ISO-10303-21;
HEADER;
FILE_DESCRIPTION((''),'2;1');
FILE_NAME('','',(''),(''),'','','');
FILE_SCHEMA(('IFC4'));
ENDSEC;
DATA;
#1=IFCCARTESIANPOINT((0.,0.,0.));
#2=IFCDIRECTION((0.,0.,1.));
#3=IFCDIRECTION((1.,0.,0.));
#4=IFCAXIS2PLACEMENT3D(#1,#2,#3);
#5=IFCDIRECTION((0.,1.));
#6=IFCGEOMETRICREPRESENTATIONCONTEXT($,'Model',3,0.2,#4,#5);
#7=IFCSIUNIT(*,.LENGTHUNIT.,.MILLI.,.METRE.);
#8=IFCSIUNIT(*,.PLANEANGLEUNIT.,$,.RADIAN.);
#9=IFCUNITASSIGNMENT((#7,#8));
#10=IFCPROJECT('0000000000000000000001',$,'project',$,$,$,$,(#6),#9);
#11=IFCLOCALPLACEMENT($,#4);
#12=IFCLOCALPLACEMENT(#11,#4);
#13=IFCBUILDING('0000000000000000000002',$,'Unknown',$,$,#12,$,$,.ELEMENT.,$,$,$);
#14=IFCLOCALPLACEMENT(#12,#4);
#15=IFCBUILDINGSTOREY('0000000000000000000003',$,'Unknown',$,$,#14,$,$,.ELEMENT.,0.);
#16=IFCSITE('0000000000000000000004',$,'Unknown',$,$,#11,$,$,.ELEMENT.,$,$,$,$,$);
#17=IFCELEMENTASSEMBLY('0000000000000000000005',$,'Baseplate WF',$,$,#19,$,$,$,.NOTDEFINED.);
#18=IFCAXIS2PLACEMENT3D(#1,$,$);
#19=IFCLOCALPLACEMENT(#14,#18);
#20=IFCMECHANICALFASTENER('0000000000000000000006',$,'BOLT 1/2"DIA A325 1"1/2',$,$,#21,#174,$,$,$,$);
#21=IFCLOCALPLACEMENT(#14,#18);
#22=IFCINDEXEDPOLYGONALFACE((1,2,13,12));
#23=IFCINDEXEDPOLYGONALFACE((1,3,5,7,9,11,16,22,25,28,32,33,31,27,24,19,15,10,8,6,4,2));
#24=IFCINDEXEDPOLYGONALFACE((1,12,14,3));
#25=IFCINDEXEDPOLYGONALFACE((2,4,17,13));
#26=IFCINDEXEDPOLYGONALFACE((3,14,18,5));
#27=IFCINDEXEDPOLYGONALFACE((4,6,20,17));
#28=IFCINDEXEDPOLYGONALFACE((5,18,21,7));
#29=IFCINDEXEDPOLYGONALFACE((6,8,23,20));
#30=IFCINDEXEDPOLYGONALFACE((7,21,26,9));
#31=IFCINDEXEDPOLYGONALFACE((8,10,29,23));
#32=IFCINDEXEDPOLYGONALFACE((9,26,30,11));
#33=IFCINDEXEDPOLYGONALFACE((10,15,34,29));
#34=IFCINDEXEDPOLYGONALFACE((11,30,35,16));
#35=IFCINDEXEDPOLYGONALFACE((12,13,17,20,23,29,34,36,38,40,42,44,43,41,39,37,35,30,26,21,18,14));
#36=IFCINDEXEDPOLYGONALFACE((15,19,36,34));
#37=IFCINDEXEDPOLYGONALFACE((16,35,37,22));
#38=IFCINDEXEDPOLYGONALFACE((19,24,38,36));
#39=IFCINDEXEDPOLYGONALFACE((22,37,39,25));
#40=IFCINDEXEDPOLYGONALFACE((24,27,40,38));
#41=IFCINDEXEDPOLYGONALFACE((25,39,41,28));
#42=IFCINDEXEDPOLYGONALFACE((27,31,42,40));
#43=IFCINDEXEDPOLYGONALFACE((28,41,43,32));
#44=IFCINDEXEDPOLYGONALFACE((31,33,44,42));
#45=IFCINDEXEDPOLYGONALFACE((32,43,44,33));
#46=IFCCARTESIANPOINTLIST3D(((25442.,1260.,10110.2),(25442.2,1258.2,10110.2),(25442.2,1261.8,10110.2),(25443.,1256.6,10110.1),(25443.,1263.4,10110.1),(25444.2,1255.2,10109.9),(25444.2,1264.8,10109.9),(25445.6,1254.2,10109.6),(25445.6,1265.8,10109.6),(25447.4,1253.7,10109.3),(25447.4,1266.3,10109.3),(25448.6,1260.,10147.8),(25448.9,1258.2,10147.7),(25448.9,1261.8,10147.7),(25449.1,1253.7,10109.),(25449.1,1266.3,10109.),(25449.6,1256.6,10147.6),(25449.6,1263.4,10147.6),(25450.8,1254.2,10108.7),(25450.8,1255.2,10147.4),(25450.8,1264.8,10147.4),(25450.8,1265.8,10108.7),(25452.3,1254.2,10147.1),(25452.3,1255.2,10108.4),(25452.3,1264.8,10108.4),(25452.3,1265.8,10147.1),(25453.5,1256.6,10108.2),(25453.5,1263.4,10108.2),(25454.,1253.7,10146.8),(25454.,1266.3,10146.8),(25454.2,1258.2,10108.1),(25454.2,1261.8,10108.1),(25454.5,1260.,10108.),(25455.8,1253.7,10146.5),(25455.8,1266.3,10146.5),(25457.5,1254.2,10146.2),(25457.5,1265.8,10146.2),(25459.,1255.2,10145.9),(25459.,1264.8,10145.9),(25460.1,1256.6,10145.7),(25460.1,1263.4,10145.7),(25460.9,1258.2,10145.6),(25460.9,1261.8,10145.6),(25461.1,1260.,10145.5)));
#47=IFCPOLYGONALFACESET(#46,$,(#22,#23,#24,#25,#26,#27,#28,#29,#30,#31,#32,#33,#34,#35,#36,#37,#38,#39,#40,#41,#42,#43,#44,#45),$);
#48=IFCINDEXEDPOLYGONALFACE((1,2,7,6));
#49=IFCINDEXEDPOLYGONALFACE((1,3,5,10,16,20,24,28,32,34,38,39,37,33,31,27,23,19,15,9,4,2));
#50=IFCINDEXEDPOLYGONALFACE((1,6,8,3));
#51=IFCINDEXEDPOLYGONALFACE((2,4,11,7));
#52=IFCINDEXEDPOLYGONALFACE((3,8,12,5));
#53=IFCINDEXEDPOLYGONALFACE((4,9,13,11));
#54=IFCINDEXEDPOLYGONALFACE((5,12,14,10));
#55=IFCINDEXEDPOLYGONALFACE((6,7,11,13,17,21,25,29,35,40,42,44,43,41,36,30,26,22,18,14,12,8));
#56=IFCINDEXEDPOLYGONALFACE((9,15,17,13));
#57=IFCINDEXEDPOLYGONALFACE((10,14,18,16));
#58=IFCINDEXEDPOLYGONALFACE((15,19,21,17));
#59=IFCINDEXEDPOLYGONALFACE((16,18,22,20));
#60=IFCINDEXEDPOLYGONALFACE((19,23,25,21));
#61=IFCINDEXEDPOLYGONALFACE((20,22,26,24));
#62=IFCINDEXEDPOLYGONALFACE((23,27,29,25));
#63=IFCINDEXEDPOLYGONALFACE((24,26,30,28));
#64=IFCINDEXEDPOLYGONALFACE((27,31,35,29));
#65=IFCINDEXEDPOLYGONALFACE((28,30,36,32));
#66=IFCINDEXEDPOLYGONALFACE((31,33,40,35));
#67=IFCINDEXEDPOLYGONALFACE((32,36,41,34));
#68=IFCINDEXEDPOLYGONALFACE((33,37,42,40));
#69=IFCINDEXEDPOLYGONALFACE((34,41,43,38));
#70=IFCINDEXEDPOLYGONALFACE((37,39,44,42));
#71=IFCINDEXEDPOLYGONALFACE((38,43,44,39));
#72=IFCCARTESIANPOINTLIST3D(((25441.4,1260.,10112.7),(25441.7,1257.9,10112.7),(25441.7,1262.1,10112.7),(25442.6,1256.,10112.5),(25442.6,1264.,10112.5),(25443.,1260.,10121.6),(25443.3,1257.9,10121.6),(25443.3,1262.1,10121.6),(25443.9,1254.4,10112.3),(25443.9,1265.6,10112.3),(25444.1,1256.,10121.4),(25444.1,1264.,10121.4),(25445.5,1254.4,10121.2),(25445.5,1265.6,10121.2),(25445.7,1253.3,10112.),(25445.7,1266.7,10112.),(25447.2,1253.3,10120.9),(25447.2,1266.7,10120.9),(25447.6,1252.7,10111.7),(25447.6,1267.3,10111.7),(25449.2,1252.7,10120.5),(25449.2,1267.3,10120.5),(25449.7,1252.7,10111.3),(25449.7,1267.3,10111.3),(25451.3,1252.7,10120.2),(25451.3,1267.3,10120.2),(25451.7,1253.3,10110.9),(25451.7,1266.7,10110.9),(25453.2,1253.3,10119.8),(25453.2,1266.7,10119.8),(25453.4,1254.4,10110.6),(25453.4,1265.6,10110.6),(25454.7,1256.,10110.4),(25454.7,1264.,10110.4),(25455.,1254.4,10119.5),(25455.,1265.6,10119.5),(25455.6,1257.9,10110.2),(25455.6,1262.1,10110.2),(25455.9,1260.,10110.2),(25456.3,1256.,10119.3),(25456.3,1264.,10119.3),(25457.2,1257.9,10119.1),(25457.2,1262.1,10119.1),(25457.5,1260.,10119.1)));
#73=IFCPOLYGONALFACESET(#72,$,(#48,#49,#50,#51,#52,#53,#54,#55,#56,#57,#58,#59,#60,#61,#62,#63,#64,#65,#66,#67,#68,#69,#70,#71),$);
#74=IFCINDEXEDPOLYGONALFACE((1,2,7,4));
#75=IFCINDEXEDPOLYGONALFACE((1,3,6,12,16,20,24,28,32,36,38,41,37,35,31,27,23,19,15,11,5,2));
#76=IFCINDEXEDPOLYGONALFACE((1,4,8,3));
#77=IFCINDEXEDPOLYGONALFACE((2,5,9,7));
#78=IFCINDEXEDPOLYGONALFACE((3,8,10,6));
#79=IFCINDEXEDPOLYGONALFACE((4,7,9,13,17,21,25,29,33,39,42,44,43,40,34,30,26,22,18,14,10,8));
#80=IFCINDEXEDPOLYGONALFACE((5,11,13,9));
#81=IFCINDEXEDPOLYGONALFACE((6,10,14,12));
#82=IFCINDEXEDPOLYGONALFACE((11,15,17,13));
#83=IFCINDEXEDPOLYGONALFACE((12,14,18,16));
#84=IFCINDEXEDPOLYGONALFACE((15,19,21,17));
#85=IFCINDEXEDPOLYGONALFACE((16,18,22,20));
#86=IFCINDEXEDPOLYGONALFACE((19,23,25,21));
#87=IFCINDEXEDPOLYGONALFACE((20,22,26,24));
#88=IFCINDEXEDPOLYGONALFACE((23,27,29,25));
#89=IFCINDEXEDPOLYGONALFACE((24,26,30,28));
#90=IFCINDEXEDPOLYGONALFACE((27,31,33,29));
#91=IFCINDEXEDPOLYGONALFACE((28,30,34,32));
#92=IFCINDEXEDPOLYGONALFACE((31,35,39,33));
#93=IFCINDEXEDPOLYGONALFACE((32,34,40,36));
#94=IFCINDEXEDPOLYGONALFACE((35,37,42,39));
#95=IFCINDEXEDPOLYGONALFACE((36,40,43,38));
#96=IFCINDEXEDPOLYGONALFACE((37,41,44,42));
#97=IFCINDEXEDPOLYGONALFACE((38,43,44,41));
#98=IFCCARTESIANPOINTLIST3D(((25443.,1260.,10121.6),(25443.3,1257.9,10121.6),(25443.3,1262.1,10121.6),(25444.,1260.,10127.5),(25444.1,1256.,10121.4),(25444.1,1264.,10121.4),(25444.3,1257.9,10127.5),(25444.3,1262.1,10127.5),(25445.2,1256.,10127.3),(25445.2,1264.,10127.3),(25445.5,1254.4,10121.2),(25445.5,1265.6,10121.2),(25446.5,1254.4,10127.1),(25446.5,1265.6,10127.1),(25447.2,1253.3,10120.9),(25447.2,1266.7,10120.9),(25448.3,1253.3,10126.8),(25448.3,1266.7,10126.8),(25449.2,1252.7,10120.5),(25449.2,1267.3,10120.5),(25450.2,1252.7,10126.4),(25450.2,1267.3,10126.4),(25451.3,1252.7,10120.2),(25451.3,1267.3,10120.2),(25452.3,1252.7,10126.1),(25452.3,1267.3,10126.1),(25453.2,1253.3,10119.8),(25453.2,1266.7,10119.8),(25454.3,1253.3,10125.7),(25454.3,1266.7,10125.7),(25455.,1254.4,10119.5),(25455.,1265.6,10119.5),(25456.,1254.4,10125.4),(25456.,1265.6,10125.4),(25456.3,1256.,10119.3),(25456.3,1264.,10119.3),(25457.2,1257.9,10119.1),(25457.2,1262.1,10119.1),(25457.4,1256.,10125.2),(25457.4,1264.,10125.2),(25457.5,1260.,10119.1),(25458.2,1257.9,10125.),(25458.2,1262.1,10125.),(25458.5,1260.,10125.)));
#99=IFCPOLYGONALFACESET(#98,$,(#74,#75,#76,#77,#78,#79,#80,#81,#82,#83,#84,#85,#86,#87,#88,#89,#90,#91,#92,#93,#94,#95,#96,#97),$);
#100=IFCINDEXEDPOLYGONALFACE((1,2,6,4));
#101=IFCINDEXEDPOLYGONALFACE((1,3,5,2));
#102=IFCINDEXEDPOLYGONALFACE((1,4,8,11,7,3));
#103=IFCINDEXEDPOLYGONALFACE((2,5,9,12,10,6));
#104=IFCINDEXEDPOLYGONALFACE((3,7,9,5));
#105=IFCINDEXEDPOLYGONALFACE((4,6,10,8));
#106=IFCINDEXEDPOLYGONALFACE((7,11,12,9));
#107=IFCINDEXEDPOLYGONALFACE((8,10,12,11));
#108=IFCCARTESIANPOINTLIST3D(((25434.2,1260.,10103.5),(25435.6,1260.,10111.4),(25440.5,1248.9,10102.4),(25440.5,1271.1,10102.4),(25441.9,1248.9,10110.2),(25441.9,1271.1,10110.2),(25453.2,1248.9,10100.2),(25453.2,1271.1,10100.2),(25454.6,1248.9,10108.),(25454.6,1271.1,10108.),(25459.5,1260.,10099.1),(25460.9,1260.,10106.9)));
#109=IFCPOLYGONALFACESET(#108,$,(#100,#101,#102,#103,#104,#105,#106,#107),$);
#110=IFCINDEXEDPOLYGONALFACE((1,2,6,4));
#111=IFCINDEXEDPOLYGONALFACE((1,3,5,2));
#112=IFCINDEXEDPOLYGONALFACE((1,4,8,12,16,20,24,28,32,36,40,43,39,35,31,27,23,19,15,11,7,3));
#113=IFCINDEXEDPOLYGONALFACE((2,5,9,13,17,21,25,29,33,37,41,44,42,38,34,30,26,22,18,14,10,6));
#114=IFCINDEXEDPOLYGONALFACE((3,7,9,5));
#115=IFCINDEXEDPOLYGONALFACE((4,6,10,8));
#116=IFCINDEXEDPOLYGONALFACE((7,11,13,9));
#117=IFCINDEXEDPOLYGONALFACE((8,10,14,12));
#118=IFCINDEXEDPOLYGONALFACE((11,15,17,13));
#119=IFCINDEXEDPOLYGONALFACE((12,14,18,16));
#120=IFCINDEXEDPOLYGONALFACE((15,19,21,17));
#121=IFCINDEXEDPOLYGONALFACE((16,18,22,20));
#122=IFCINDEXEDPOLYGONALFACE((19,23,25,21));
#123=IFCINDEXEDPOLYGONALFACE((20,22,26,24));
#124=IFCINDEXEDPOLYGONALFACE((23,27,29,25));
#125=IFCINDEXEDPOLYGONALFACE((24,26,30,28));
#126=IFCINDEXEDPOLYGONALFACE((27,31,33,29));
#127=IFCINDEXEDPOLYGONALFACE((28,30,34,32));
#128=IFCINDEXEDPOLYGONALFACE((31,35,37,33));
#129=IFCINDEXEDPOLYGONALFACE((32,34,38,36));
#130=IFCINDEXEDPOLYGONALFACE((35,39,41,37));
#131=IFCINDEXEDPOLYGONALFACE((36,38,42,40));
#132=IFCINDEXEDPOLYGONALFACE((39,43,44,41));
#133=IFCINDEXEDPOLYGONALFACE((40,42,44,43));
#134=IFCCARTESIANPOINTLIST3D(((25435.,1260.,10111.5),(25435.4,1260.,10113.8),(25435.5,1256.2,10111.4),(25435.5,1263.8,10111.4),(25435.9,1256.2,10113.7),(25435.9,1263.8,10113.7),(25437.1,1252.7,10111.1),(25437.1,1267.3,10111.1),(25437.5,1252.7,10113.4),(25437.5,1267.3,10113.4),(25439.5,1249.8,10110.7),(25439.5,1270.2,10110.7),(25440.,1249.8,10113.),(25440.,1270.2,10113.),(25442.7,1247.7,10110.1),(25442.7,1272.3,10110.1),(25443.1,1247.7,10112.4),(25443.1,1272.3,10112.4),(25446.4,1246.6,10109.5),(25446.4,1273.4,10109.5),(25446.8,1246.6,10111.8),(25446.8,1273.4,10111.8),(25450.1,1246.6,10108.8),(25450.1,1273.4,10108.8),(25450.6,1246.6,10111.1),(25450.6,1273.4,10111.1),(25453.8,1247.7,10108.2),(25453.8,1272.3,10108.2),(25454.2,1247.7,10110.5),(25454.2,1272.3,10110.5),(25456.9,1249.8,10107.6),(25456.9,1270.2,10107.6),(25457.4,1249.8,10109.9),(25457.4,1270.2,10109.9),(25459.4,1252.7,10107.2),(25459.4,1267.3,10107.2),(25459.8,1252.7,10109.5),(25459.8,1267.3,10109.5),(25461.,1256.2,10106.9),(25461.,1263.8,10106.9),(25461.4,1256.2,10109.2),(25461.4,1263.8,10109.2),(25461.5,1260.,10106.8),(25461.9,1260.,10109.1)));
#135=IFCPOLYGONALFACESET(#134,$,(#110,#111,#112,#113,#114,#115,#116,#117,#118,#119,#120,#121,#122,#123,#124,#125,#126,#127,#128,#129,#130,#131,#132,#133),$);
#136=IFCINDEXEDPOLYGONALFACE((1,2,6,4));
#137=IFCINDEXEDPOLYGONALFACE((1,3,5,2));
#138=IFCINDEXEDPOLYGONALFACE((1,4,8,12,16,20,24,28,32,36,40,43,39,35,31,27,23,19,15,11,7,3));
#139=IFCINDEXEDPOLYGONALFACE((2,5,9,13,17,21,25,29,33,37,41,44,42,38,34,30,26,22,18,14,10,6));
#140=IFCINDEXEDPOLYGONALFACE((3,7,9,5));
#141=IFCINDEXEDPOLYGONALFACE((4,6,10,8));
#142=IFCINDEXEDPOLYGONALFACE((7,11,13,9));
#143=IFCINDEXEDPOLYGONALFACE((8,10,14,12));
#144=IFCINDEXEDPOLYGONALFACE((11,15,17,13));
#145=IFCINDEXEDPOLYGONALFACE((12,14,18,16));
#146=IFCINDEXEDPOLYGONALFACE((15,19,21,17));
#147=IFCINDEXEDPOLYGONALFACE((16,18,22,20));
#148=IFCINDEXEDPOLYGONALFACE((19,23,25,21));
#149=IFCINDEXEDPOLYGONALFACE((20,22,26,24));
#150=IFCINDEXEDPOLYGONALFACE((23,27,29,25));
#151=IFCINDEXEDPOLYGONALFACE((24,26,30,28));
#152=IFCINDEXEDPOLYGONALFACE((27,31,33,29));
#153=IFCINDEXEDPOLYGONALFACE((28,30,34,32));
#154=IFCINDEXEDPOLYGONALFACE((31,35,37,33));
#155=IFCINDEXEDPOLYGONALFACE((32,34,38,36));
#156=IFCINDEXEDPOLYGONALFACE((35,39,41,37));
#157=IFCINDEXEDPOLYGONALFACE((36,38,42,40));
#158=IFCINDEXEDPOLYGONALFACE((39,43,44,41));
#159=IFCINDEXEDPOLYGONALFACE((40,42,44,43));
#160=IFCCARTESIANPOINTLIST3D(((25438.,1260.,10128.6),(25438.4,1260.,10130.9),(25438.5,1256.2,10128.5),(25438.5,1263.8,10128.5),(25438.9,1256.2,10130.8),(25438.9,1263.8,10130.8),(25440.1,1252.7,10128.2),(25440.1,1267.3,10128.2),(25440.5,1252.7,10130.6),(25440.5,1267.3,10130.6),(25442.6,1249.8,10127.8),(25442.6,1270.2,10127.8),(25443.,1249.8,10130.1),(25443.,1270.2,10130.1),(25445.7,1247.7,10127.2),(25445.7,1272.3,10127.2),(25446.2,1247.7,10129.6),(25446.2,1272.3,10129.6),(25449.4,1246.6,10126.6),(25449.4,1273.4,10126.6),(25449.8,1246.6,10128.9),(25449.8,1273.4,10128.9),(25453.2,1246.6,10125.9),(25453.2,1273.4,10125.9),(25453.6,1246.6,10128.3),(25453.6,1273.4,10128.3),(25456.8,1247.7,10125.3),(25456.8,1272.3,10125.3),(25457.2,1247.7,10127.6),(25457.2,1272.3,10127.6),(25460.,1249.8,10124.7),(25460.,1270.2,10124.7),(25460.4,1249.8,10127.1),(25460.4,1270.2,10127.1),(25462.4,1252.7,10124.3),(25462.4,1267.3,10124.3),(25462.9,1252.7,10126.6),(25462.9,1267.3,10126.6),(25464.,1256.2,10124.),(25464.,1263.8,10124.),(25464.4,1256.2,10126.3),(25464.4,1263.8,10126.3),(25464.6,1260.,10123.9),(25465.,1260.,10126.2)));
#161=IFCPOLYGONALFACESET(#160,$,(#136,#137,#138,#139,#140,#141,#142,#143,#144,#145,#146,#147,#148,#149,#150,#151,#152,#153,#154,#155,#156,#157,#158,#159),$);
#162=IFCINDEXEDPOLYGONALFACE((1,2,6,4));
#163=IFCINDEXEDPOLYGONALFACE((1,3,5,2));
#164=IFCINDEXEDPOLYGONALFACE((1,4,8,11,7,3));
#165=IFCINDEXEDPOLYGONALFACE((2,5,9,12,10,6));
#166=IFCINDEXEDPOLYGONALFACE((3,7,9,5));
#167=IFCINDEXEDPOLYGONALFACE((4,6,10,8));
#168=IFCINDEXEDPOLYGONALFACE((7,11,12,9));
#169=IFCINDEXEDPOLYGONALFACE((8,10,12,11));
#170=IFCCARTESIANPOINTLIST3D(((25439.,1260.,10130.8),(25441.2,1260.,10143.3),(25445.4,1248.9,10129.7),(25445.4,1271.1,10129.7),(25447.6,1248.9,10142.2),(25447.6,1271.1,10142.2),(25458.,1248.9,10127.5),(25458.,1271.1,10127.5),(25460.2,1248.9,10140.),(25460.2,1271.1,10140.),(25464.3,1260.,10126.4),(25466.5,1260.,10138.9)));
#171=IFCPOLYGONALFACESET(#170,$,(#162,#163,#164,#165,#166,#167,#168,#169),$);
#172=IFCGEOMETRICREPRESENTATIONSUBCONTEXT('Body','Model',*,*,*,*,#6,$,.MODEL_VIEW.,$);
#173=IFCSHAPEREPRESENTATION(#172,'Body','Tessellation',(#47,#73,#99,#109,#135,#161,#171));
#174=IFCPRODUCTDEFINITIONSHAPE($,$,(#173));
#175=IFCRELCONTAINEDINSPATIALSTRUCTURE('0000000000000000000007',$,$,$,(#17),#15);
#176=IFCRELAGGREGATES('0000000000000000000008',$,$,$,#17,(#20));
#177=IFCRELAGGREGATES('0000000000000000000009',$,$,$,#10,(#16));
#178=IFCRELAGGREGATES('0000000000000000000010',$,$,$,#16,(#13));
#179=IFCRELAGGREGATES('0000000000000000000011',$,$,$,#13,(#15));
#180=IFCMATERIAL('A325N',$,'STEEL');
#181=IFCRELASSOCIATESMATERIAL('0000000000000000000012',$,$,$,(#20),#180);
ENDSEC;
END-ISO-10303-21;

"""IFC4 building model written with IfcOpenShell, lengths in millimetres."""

from ifc_helpers import new_model, si_unit, direction, frame, origin_with_axes, place, context, subcontext, project, spatial, line, arc, indexed_curve, outline, extrude, source, transform, mapped, material, element, aggregate, save


model = new_model("IFC4")

# Units and contexts
model_context = context("Model", 3, precision=0.2, world=origin_with_axes(), true_north=direction((0.0, 1.0)))
body_context = subcontext(model_context, "Body", "Model", "MODEL_VIEW")
ifc_project = project(units=[si_unit("LENGTHUNIT", "METRE", prefix="MILLI"), si_unit("PLANEANGLEUNIT", "RADIAN")], contexts=[model_context])

# Site, building, storey
site_placement = place(None, origin_with_axes())
site = spatial("IfcSite", under=ifc_project, at=site_placement, Name="Unknown", CompositionType="ELEMENT")
building_placement = place(site_placement, origin_with_axes())
building = spatial("IfcBuilding", under=site, at=building_placement, Name="Unknown", CompositionType="ELEMENT")
storey_placement = place(building_placement, origin_with_axes())
storey = spatial("IfcBuildingStorey", under=building, at=storey_placement, Name="Unknown", CompositionType="ELEMENT", Elevation=0.0)

# Element assembly
assembly_1_placement = place(storey_placement, frame((25480.3, 1290.0, 10118.1), z_axis=(-0.173648, 0.0, -0.984808), x_axis=(0.0, -1.0, 0.0)))
assembly_1 = element("IfcElementAssembly", 1, at=assembly_1_placement, inside=storey, Name="Baseplate WF", PredefinedType="NOTDEFINED")

# Mechanical fastener
ifc_material_1 = material(Name="A325N", Category="STEEL")
shared_shape_1 = source(origin_with_axes(), body_context, "Body", "SweptSolid", [
    extrude(outline(indexed_curve([(6.3, 0.0), (0.0, 6.3), (-6.3, 0.0), (0.0, -6.3)], segments=[arc(1, 2, 3), arc(3, 4, 1)])), frame((0.0, 0.0, 17.4), z_axis=(0.0, 0.0, -1.0), x_axis=(0.0, 1.0, 0.0)), (0.0, 0.0, 1.0), 38.1),
    extrude(outline(indexed_curve([(7.3, 0.0), (0.0, 7.3), (-7.3, 0.0), (0.0, -7.3)], segments=[arc(1, 2, 3), arc(3, 4, 1)])), frame((0.0, 0.0, 15.0), z_axis=(0.0, 0.0, -1.0), x_axis=(0.0, 1.0, 0.0)), (0.0, 0.0, 1.0), 9.0),
    extrude(outline(indexed_curve([(7.3, 0.0), (0.0, 7.3), (-7.3, 0.0), (0.0, -7.3)], segments=[arc(1, 2, 3), arc(3, 4, 1)])), frame((0.0, 0.0, 6.0), z_axis=(0.0, 0.0, -1.0), x_axis=(0.0, 1.0, 0.0)), (0.0, 0.0, 1.0), 6.0),
    extrude(outline(indexed_curve([(12.8, 0.0), (6.4, 11.1), (-6.4, 11.1), (-12.8, 0.0), (-6.4, -11.1), (6.4, -11.1)], segments=[line(1, 2, 3, 4, 5, 6, 1)])), frame((0.0, 0.0, 25.3), z_axis=(0.0, 0.0, -1.0), x_axis=(0.0, 1.0, 0.0)), (0.0, 0.0, 1.0), 7.9),
    extrude(outline(indexed_curve([(13.5, 0.0), (0.0, 13.5), (-13.5, 0.0), (0.0, -13.5)], segments=[arc(1, 2, 3), arc(3, 4, 1)])), frame((0.0, 0.0, 17.4), z_axis=(0.0, 0.0, -1.0), x_axis=(0.0, 1.0, 0.0)), (0.0, 0.0, 1.0), 2.4),
    extrude(outline(indexed_curve([(13.5, 0.0), (0.0, 13.5), (-13.5, 0.0), (0.0, -13.5)], segments=[arc(1, 2, 3), arc(3, 4, 1)])), frame((0.0, 0.0, 0.0), z_axis=(0.0, 0.0, -1.0), x_axis=(0.0, 1.0, 0.0)), (0.0, 0.0, 1.0), 2.4),
    extrude(outline(indexed_curve([(12.8, 0.0), (6.4, 11.1), (-6.4, 11.1), (-12.8, 0.0), (-6.4, -11.1), (6.4, -11.1)], segments=[line(1, 2, 3, 4, 5, 6, 1)])), frame((0.0, 0.0, -2.4), z_axis=(0.0, 0.0, -1.0), x_axis=(0.0, 1.0, 0.0)), (0.0, 0.0, 1.0), 12.7),
])
mechanical_fastener_1_placement = place(assembly_1_placement, frame((30.0, 30.0, -3.0), z_axis=(0.0, 0.0, 1.0), x_axis=(-1.0, 0.0, 0.0)))
mechanical_fastener_1 = element("IfcMechanicalFastener", 2, at=mechanical_fastener_1_placement, material=ifc_material_1, Name="BOLT 1/2\"DIA A325 1\"1/2", context=body_context, shape_type="MappedRepresentation", body=[
    mapped(shared_shape_1, transform((0.0, 0.0, 0.0))),
])
aggregate(assembly_1, [mechanical_fastener_1])

save(model, "model.ifc")
